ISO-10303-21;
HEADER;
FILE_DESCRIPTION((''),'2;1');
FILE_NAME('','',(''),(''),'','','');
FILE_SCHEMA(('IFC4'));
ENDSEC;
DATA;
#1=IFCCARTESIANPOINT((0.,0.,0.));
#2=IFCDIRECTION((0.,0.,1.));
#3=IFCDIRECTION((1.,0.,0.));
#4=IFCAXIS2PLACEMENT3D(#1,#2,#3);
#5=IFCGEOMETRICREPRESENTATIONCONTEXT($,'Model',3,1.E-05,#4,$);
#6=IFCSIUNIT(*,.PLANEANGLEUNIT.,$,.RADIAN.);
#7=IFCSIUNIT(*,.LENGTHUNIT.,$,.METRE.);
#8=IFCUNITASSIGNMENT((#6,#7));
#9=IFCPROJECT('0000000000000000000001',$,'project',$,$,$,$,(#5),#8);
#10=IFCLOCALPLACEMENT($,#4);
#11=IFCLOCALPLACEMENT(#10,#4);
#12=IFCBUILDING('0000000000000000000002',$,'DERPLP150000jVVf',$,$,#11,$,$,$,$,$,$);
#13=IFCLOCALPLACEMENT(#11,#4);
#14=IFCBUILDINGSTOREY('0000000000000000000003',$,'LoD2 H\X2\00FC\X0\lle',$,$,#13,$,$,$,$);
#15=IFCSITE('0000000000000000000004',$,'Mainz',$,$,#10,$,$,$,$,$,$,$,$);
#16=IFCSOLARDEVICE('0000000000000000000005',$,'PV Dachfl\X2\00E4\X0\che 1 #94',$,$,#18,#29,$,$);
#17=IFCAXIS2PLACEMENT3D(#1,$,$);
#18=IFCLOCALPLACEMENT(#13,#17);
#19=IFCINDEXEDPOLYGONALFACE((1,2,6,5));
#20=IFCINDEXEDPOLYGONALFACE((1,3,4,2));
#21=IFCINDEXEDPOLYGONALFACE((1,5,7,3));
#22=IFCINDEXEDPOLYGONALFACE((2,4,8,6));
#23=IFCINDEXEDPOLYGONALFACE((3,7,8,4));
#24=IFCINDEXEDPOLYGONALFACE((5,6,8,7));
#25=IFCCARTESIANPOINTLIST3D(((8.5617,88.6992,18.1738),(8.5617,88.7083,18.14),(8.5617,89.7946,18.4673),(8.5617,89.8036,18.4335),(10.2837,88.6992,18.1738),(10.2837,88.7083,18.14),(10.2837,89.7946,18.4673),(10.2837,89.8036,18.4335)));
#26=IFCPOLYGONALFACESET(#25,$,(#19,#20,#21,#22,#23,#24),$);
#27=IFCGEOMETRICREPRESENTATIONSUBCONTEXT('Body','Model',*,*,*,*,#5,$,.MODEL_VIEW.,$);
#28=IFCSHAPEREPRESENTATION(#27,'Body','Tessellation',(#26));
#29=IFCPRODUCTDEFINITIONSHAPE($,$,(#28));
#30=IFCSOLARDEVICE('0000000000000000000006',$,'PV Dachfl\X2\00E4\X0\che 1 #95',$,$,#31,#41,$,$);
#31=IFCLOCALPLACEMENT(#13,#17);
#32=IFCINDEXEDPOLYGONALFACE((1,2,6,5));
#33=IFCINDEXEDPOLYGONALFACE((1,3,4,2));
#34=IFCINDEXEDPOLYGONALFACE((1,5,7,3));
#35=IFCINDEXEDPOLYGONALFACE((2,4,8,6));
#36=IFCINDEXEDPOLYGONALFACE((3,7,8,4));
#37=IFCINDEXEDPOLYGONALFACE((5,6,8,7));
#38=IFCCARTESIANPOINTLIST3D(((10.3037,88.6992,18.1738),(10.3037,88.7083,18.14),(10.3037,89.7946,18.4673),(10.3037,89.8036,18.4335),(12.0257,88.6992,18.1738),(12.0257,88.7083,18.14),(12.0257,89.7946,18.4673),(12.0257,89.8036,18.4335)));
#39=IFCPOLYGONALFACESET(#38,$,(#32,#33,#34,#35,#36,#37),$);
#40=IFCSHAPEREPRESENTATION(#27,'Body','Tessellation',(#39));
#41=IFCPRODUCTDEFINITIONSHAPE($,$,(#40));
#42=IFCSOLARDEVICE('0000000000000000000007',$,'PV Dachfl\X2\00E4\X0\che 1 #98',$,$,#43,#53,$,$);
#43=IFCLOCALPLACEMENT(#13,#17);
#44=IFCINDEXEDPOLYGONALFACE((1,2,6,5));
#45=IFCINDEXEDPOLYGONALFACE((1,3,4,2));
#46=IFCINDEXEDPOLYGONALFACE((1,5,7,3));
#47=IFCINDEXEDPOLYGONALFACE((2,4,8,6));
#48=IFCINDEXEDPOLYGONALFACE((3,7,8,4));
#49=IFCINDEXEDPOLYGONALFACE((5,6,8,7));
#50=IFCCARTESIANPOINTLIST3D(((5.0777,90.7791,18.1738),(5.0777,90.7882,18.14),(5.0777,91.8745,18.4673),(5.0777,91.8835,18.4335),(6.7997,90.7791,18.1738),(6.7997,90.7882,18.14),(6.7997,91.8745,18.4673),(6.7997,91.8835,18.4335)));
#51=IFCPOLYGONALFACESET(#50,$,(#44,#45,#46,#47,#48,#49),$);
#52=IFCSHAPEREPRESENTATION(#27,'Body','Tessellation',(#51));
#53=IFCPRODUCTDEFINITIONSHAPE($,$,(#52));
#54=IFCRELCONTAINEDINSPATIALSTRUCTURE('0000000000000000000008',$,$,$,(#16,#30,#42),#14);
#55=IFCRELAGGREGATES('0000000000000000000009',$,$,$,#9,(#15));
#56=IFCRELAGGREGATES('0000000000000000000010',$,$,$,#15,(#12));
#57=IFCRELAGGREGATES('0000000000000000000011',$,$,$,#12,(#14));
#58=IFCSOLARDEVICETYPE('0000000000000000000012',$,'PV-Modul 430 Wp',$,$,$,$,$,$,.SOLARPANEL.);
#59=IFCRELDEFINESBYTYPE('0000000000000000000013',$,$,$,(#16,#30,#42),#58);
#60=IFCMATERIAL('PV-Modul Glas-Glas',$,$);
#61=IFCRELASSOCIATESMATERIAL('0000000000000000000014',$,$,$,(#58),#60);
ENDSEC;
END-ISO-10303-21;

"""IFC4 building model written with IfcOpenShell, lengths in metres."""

from ifc_helpers import new_model, si_unit, frame, frame_2d, origin, origin_with_axes, place, context, subcontext, project, spatial, rectangle, extrude, source, transform, mapped, material, type_object, type_shapes, element, save


model = new_model("IFC4")

# Units and contexts
model_context = context("Model", 3, precision=1e-05, world=origin_with_axes())
body_context = subcontext(model_context, "Body", "Model", "MODEL_VIEW")
ifc_project = project(units=[si_unit("PLANEANGLEUNIT", "RADIAN"), si_unit("LENGTHUNIT", "METRE")], contexts=[model_context])

# Site, building, storey
site_placement = place(None, origin_with_axes())
site = spatial("IfcSite", under=ifc_project, at=site_placement, Name="Mainz")
building_placement = place(site_placement, origin_with_axes())
building = spatial("IfcBuilding", under=site, at=building_placement, Name="DERPLP150000jVVf")
storey_placement = place(building_placement, origin_with_axes())
storey = spatial("IfcBuildingStorey", under=building, at=storey_placement, Name="LoD2 Hülle")

# Solar devices
ifc_material = material(Name="PV-Modul Glas-Glas")
solar_device_type = type_object("IfcSolarDeviceType", Name="PV-Modul 430 Wp", PredefinedType="SOLARPANEL", material=ifc_material)
shared_shape = source(origin_with_axes(), body_context, "Body", "SweptSolid", [
    extrude(rectangle(XDim=1.722, YDim=1.134, at=frame_2d((0.861, 0.567))), origin(), (0.0, 0.0, 1.0), 0.035),
])
type_shapes(solar_device_type, [shared_shape])
for number, where, z_axis, x_axis, name in (
    (1, (8.5617, 88.7083, 18.14), (0.0, -0.258819, 0.965926), (1.0, 0.0, 0.0), "PV Dachfläche 1 #94"),
    (2, (10.3037, 88.7083, 18.14), (0.0, -0.258819, 0.965926), (1.0, 0.0, 0.0), "PV Dachfläche 1 #95"),
    (3, (5.0777, 90.7882, 18.14), (0.0, -0.258819, 0.965926), (1.0, 0.0, 0.0), "PV Dachfläche 1 #98"),
):
    element("IfcSolarDevice", number, at=place(storey_placement, frame(where, z_axis=z_axis, x_axis=x_axis)), inside=storey, type_object=solar_device_type, Name=name, context=body_context, shape_type="MappedRepresentation", body=[
        mapped(shared_shape, transform((0.0, 0.0, 0.0), x_axis=(1.0, 0.0, 0.0), y_axis=(0.0, 1.0, 0.0), z_axis=(0.0, 0.0, 1.0), scale=1.0)),
    ])

save(model, "model.ifc")
